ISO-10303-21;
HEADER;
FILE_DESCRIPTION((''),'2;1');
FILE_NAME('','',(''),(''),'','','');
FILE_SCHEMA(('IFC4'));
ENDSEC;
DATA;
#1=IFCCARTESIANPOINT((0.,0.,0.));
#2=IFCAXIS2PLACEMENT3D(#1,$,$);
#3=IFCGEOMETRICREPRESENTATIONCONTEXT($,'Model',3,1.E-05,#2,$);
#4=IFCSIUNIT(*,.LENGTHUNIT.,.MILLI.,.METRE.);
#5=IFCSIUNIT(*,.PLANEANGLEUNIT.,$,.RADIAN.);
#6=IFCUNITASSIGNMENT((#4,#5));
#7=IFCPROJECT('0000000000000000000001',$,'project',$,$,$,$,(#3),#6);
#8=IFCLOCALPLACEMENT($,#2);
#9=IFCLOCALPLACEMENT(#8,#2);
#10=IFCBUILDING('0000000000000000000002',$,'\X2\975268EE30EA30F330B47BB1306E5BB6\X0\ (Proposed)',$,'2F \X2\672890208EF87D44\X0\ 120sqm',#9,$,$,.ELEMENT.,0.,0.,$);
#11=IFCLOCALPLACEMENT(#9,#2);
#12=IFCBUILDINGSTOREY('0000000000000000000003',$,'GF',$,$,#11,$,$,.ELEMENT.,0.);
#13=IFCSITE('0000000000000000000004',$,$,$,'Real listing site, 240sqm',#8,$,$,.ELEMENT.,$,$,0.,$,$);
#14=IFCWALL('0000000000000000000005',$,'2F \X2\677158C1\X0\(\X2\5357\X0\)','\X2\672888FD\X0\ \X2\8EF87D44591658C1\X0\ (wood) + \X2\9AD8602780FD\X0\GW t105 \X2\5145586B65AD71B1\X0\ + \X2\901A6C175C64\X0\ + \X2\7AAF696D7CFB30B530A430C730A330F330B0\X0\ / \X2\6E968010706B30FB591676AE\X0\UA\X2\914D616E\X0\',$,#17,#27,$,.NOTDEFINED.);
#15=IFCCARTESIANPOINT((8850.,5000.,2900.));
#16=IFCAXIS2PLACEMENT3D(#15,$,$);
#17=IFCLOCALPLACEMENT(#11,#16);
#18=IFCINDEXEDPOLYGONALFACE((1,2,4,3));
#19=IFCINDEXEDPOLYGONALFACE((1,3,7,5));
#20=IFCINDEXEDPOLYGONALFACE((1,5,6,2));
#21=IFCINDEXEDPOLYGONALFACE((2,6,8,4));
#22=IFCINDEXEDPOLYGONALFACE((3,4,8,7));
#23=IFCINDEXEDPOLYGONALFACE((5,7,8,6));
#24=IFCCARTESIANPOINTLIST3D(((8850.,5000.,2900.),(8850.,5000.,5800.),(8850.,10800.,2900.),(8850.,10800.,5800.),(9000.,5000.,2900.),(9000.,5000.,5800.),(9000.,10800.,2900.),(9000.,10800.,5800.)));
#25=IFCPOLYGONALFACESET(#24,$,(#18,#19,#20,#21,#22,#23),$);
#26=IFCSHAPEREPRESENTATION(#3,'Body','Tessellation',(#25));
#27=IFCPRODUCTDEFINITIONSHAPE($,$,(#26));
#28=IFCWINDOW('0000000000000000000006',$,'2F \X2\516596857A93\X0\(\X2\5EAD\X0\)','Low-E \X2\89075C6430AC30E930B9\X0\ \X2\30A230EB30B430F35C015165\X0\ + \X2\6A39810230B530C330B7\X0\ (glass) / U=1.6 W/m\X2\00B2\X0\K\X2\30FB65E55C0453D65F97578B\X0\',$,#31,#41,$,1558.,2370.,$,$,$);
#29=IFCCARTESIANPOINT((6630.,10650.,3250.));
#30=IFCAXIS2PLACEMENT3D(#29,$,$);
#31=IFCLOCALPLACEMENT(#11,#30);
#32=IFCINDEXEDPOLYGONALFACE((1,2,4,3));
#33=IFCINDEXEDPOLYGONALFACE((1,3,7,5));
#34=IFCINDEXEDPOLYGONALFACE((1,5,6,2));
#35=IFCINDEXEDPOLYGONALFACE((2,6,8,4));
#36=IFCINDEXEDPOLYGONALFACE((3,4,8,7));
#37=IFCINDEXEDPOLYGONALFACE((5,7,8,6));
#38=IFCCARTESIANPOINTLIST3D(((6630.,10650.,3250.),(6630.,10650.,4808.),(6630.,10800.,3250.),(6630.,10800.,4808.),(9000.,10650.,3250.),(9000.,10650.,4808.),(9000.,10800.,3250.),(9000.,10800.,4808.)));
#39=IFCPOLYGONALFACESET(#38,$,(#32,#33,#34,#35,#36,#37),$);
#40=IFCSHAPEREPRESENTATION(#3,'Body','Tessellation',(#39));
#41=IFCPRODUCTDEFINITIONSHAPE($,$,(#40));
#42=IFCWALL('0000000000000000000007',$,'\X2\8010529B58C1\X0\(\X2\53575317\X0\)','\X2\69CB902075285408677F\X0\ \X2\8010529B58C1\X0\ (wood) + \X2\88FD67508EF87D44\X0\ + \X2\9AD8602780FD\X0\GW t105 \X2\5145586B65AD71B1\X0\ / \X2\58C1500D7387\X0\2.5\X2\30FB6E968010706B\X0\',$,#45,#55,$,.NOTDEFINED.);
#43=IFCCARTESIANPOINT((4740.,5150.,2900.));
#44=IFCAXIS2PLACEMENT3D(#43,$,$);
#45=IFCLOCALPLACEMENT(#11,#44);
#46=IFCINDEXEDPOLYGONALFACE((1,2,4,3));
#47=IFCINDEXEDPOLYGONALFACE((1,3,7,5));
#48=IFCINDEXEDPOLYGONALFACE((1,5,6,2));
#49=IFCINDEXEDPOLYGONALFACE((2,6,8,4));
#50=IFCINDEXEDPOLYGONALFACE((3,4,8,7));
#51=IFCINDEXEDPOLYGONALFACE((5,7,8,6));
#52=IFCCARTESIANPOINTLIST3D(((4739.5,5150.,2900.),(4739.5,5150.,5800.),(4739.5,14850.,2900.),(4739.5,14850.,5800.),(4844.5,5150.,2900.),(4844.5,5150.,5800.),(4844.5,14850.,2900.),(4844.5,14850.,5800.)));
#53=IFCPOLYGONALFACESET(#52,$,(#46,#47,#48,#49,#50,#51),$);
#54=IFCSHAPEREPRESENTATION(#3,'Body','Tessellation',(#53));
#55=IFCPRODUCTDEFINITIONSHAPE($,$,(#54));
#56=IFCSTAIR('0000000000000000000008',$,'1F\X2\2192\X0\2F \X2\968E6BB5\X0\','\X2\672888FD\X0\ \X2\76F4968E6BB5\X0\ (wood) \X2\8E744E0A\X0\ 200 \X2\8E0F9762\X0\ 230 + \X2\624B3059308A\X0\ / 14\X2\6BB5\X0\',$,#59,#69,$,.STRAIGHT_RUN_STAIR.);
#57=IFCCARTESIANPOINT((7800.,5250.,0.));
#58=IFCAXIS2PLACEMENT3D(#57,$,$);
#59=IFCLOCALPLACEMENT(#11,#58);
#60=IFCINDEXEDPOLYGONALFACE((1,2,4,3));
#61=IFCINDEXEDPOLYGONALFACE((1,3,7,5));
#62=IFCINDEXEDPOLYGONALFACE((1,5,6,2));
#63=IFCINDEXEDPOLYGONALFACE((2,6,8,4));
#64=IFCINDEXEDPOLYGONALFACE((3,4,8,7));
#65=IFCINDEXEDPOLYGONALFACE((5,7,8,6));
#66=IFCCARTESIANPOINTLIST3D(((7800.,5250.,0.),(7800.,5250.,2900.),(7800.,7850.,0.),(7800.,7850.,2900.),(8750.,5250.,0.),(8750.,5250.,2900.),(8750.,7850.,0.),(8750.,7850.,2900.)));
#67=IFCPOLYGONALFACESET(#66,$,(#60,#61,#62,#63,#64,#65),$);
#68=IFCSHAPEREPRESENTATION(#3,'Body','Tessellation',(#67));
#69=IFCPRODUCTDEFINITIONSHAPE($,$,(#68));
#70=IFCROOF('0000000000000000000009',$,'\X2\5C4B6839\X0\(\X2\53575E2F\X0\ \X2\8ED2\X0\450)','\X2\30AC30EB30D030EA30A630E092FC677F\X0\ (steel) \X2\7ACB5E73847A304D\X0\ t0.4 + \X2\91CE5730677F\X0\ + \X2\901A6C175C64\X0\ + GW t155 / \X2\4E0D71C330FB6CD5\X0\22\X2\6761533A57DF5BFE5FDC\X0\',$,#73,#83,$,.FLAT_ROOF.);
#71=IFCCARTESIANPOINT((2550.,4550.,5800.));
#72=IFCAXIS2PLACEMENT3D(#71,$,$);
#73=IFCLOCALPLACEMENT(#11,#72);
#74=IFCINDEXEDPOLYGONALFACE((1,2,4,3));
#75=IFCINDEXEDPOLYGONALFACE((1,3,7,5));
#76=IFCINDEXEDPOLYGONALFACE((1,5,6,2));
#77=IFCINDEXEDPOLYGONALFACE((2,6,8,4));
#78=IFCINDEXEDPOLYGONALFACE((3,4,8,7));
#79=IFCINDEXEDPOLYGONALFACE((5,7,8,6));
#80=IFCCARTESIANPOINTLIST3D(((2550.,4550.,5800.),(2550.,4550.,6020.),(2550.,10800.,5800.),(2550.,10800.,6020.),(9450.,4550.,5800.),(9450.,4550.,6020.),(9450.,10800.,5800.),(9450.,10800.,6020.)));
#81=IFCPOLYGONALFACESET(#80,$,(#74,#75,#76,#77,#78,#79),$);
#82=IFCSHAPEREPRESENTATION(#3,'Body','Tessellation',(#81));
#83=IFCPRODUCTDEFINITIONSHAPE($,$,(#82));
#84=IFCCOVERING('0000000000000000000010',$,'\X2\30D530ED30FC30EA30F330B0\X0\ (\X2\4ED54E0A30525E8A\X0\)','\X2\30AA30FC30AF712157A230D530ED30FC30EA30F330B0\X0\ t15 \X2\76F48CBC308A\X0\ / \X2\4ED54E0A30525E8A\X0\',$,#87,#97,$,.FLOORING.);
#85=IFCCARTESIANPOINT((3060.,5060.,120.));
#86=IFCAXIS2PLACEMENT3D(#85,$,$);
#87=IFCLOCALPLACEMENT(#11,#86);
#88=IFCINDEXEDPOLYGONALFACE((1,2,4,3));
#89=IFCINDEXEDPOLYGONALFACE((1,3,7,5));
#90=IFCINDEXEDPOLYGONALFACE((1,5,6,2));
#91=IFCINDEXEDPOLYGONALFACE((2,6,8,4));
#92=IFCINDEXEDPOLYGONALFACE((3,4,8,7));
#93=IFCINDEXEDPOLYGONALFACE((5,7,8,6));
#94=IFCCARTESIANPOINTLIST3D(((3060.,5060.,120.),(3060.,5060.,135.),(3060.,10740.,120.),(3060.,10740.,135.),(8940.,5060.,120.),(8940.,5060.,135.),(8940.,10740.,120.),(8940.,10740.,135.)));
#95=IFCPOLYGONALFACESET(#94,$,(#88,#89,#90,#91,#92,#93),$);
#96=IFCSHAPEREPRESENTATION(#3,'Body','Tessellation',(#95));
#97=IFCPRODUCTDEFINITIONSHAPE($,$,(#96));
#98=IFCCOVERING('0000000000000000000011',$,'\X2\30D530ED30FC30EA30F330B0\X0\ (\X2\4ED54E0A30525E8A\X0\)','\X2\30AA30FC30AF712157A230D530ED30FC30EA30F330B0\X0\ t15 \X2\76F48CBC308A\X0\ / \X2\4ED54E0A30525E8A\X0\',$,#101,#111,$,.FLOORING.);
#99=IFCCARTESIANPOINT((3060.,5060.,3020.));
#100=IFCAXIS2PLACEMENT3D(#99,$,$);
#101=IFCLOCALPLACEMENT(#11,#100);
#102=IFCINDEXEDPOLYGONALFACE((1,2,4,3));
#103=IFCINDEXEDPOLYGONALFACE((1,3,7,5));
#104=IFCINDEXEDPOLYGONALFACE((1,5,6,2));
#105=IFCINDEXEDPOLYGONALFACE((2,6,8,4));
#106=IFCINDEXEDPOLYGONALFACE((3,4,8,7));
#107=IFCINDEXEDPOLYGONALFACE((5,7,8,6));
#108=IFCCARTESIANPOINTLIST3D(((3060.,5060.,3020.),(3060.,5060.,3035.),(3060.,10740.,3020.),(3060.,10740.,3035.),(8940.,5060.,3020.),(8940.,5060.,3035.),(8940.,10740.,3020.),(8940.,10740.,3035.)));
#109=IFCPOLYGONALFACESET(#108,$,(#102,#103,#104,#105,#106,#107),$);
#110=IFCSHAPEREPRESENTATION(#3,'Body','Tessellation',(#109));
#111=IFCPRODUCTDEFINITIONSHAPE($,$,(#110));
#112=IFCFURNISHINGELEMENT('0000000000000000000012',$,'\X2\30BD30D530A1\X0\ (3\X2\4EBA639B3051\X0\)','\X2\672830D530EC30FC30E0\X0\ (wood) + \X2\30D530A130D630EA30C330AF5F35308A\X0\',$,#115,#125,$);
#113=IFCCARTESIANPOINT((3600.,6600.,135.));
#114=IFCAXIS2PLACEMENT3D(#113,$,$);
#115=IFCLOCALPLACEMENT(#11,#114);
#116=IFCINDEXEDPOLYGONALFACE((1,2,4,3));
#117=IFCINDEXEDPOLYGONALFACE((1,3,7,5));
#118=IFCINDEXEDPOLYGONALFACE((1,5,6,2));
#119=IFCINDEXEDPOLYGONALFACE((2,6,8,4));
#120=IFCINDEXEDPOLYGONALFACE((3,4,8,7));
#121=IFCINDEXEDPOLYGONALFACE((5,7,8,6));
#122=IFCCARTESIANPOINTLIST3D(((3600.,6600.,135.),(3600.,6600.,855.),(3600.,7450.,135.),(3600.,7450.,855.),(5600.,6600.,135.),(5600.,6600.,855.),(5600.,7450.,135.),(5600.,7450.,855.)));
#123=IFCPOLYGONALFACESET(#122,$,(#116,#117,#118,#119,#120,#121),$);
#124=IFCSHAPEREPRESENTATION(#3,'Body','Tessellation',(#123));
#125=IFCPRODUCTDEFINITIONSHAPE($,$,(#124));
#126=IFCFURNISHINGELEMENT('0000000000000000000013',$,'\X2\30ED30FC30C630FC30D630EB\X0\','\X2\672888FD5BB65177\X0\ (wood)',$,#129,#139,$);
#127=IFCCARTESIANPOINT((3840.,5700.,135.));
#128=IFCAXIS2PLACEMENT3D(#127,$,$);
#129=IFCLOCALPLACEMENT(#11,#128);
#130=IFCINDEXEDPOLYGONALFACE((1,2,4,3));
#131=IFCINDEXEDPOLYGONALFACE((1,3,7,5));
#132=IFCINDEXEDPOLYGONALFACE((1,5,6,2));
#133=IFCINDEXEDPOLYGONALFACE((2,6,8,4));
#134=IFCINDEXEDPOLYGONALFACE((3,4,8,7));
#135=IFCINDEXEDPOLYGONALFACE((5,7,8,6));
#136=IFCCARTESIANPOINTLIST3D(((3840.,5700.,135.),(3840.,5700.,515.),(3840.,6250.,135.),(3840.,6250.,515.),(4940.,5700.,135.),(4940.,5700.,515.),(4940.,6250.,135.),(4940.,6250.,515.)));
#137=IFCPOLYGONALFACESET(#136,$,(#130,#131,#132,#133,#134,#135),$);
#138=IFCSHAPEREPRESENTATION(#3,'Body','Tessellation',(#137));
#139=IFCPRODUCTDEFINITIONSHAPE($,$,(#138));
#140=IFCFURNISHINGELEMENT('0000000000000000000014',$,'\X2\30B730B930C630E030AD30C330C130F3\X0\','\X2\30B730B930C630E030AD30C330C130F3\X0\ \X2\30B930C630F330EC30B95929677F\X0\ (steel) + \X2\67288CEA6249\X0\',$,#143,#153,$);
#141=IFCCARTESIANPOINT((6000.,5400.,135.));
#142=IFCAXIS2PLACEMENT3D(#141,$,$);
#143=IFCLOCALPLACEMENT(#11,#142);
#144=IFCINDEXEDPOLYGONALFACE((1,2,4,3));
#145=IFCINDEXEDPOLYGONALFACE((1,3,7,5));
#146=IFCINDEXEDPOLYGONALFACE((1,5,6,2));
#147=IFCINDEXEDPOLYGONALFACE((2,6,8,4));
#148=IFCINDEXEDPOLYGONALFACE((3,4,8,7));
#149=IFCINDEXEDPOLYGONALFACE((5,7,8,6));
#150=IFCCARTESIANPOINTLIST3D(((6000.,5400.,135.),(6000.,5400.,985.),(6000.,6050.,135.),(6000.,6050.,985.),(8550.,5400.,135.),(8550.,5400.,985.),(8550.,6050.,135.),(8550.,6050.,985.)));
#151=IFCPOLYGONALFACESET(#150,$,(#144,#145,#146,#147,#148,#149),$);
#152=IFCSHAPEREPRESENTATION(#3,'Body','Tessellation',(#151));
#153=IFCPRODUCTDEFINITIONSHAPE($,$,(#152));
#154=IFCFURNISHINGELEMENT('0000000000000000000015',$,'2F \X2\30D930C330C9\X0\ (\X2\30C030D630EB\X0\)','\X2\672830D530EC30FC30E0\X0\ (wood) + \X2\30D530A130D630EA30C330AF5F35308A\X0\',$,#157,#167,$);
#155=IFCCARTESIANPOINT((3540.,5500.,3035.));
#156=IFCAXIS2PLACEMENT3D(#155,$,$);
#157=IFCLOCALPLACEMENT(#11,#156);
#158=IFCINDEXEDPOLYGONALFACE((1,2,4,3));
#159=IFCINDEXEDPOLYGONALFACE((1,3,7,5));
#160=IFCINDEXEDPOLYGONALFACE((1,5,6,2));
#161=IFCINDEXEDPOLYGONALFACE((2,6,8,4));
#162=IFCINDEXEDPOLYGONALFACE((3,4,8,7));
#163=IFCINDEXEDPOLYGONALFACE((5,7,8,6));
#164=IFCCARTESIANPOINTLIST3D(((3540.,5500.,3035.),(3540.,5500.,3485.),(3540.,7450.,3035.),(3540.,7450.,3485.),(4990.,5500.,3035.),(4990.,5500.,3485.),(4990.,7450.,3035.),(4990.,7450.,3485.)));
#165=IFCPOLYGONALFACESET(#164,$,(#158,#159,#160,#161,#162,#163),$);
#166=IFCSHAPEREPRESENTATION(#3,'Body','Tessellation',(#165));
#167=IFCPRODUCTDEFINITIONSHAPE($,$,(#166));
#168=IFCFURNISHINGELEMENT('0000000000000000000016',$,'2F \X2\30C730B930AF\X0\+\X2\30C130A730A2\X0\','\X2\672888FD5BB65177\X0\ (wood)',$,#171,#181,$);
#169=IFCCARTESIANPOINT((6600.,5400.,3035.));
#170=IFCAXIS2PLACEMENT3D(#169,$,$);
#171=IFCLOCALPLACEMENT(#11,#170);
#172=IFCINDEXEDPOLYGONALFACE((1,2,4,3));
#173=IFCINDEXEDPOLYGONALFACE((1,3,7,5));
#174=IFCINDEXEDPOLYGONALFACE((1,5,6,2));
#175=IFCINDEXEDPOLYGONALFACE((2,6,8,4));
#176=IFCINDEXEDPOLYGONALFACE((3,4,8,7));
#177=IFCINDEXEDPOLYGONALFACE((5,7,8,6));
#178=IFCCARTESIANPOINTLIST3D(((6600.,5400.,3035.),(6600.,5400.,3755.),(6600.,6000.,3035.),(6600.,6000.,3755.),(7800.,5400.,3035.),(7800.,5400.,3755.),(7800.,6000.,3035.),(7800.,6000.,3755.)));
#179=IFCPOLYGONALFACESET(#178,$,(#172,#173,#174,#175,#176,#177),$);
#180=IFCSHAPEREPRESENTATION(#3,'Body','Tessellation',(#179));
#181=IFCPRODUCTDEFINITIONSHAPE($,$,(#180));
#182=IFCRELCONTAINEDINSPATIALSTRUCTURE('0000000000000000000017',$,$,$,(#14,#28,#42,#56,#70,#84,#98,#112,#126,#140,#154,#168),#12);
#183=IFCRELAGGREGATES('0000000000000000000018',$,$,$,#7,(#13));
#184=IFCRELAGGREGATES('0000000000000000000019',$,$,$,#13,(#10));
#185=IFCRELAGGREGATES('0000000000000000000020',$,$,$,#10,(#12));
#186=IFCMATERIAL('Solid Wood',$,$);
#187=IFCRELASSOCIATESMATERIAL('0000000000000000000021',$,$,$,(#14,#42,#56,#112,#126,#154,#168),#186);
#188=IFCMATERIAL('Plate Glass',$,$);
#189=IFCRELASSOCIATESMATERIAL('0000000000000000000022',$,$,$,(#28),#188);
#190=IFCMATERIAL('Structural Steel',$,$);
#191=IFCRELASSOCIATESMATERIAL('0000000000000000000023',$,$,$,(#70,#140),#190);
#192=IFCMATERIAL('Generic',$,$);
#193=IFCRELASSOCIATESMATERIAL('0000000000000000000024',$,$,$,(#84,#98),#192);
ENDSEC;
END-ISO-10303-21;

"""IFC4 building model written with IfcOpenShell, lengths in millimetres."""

from ifc_helpers import new_model, si_unit, frame, frame_2d, origin, place, context, project, spatial, rectangle, extrude, material, element, fill, save


model = new_model("IFC4")

# Units and contexts
model_context = context("Model", 3, precision=1e-05, world=origin())
ifc_project = project(units=[si_unit("LENGTHUNIT", "METRE", prefix="MILLI"), si_unit("PLANEANGLEUNIT", "RADIAN")], contexts=[model_context])

# Site, building, storey
site_placement = place(None, origin())
site = spatial("IfcSite", under=ifc_project, at=site_placement, ObjectType="Real listing site, 240sqm", CompositionType="ELEMENT", RefElevation=0.0)
building_placement = place(site_placement, origin())
building = spatial("IfcBuilding", under=site, at=building_placement, Name="青森リンゴ箱の家 (Proposed)", ObjectType="2F 木造軸組 120sqm", CompositionType="ELEMENT", ElevationOfRefHeight=0.0, ElevationOfTerrain=0.0)
storey_placement = place(building_placement, origin())
storey = spatial("IfcBuildingStorey", under=building, at=storey_placement, Name="GF", CompositionType="ELEMENT", Elevation=0.0)

# Shared definitions
ifc_material_1 = material(Name="Solid Wood")

# Shared definitions
ifc_material_2 = material(Name="Plate Glass")

# Wall, opening, window
wall_1_placement = place(storey_placement, frame((8850.0, 5000.0, 2900.0)))
wall_1 = element("IfcWall", 1, at=wall_1_placement, inside=storey, material=ifc_material_1, Name="2F 東壁(南)", Description="木製 軸組外壁 (wood) + 高性能GW t105 充填断熱 + 通気層 + 窯業系サイディング / 準耐火・外皮UA配慮", PredefinedType="NOTDEFINED", context=model_context, shape_type="SweptSolid", body=[
    extrude(rectangle(XDim=150.0, YDim=5800.0, at=frame_2d((75.0, 2900.0))), frame((8850.0, 5000.0, 2900.0)), (0.0, 0.0, 1.0), 2900.0),
])
opening_1_placement = place(storey_placement, frame((6630.0, 10650.0, 3250.0)))
opening_1 = element("IfcOpeningElement", 2, at=opening_1_placement, cuts=wall_1, PredefinedType="NOTDEFINED", context=model_context, shape_type="SweptSolid", body=[
    extrude(rectangle(XDim=2370.0, YDim=150.0, at=frame_2d((1185.0, 75.0))), frame((6630.0, 10650.0, 3250.0)), (0.0, 0.0, 1.0), 1558.0),
])
window_1_placement = place(storey_placement, frame((6630.0, 10650.0, 3250.0)))
window_1 = element("IfcWindow", 3, at=window_1_placement, inside=storey, material=ifc_material_2, Name="2F 入隅窓(庭)", Description="Low-E 複層ガラス アルゴン封入 + 樹脂サッシ (glass) / U=1.6 W/m²K・日射取得型", OverallHeight=1558.0, OverallWidth=2370.0, context=model_context, shape_type="SweptSolid", body=[
    extrude(rectangle(XDim=2370.0, YDim=150.0, at=frame_2d((1185.0, 75.0))), frame((6630.0, 10650.0, 3250.0)), (0.0, 0.0, 1.0), 1558.0),
])
fill(opening_1, window_1)

# Wall
wall_2_placement = place(storey_placement, frame((4740.0, 5150.0, 2900.0)))
element("IfcWall", 4, at=wall_2_placement, inside=storey, material=ifc_material_1, Name="耐力壁(南北)", Description="構造用合板 耐力壁 (wood) + 製材軸組 + 高性能GW t105 充填断熱 / 壁倍率2.5・準耐火", PredefinedType="NOTDEFINED", context=model_context, shape_type="SweptSolid", body=[
    extrude(rectangle(XDim=105.0, YDim=9700.0, at=frame_2d((52.0, 4850.0))), frame((4740.0, 5150.0, 2900.0)), (0.0, 0.0, 1.0), 2900.0),
])

# Stair
stair_placement = place(storey_placement, frame((7800.0, 5250.0, 0.0)))
element("IfcStair", 5, at=stair_placement, inside=storey, material=ifc_material_1, Name="1F→2F 階段", Description="木製 直階段 (wood) 蹴上 200 踏面 230 + 手すり / 14段", PredefinedType="STRAIGHT_RUN_STAIR", context=model_context, shape_type="SweptSolid", body=[
    extrude(rectangle(XDim=950.0, YDim=2600.0, at=frame_2d((475.0, 1300.0))), frame((7800.0, 5250.0, 0.0)), (0.0, 0.0, 1.0), 2900.0),
])

# Roof
ifc_material_3 = material(Name="Structural Steel")
for number, where, name in (
    (6, (2550.0, 4550.0, 5800.0), "屋根(南帯 軒450)"),
):
    element("IfcRoof", number, at=place(storey_placement, frame(where)), inside=storey, material=ifc_material_3, Name=name, Description="ガルバリウム鋼板 (steel) 立平葺き t0.4 + 野地板 + 通気層 + GW t155 / 不燃・法22条区域対応", PredefinedType="FLAT_ROOF", context=model_context, shape_type="SweptSolid", body=[
        extrude(rectangle(XDim=6900.0, YDim=6250.0, at=frame_2d((3450.0, 3125.0))), frame((2550.0, 4550.0, 5800.0)), (0.0, 0.0, 1.0), 220.0),
    ])

# Coverings
ifc_material_4 = material(Name="Generic")
covering_1_placement = place(storey_placement, frame((3060.0, 5060.0, 120.0)))
element("IfcCovering", 7, at=covering_1_placement, inside=storey, material=ifc_material_4, Name="フローリング (仕上げ床)", Description="オーク無垢フローリング t15 直貼り / 仕上げ床", PredefinedType="FLOORING", context=model_context, shape_type="SweptSolid", body=[
    extrude(rectangle(XDim=5880.0, YDim=5680.0, at=frame_2d((2940.0, 2840.0))), frame((3060.0, 5060.0, 120.0)), (0.0, 0.0, 1.0), 15.0),
])
covering_2_placement = place(storey_placement, frame((3060.0, 5060.0, 3020.0)))
element("IfcCovering", 8, at=covering_2_placement, inside=storey, material=ifc_material_4, Name="フローリング (仕上げ床)", Description="オーク無垢フローリング t15 直貼り / 仕上げ床", PredefinedType="FLOORING", context=model_context, shape_type="SweptSolid", body=[
    extrude(rectangle(XDim=5880.0, YDim=5680.0, at=frame_2d((2940.0, 2840.0))), frame((3060.0, 5060.0, 3020.0)), (0.0, 0.0, 1.0), 15.0),
])

# Furnishing elements
furnishing_1_placement = place(storey_placement, frame((3600.0, 6600.0, 135.0)))
element("IfcFurnishingElement", 9, at=furnishing_1_placement, inside=storey, material=ifc_material_1, Name="ソファ (3人掛け)", Description="木フレーム (wood) + ファブリック張り", context=model_context, shape_type="SweptSolid", body=[
    extrude(rectangle(XDim=2000.0, YDim=850.0, at=frame_2d((1000.0, 425.0))), frame((3600.0, 6600.0, 135.0)), (0.0, 0.0, 1.0), 720.0),
])
furnishing_2_placement = place(storey_placement, frame((3840.0, 5700.0, 135.0)))
element("IfcFurnishingElement", 10, at=furnishing_2_placement, inside=storey, material=ifc_material_1, Name="ローテーブル", Description="木製家具 (wood)", context=model_context, shape_type="SweptSolid", body=[
    extrude(rectangle(XDim=1100.0, YDim=550.0, at=frame_2d((550.0, 275.0))), frame((3840.0, 5700.0, 135.0)), (0.0, 0.0, 1.0), 380.0),
])
furnishing_3_placement = place(storey_placement, frame((6000.0, 5400.0, 135.0)))
element("IfcFurnishingElement", 11, at=furnishing_3_placement, inside=storey, material=ifc_material_3, Name="システムキッチン", Description="システムキッチン ステンレス天板 (steel) + 木質扉", context=model_context, shape_type="SweptSolid", body=[
    extrude(rectangle(XDim=2550.0, YDim=650.0, at=frame_2d((1275.0, 325.0))), frame((6000.0, 5400.0, 135.0)), (0.0, 0.0, 1.0), 850.0),
])
furnishing_4_placement = place(storey_placement, frame((3540.0, 5500.0, 3035.0)))
element("IfcFurnishingElement", 12, at=furnishing_4_placement, inside=storey, material=ifc_material_1, Name="2F ベッド (ダブル)", Description="木フレーム (wood) + ファブリック張り", context=model_context, shape_type="SweptSolid", body=[
    extrude(rectangle(XDim=1450.0, YDim=1950.0, at=frame_2d((725.0, 975.0))), frame((3540.0, 5500.0, 3035.0)), (0.0, 0.0, 1.0), 450.0),
])
furnishing_5_placement = place(storey_placement, frame((6600.0, 5400.0, 3035.0)))
element("IfcFurnishingElement", 13, at=furnishing_5_placement, inside=storey, material=ifc_material_1, Name="2F デスク+チェア", Description="木製家具 (wood)", context=model_context, shape_type="SweptSolid", body=[
    extrude(rectangle(XDim=1200.0, YDim=600.0, at=frame_2d((600.0, 300.0))), frame((6600.0, 5400.0, 3035.0)), (0.0, 0.0, 1.0), 720.0),
])

save(model, "model.ifc")
